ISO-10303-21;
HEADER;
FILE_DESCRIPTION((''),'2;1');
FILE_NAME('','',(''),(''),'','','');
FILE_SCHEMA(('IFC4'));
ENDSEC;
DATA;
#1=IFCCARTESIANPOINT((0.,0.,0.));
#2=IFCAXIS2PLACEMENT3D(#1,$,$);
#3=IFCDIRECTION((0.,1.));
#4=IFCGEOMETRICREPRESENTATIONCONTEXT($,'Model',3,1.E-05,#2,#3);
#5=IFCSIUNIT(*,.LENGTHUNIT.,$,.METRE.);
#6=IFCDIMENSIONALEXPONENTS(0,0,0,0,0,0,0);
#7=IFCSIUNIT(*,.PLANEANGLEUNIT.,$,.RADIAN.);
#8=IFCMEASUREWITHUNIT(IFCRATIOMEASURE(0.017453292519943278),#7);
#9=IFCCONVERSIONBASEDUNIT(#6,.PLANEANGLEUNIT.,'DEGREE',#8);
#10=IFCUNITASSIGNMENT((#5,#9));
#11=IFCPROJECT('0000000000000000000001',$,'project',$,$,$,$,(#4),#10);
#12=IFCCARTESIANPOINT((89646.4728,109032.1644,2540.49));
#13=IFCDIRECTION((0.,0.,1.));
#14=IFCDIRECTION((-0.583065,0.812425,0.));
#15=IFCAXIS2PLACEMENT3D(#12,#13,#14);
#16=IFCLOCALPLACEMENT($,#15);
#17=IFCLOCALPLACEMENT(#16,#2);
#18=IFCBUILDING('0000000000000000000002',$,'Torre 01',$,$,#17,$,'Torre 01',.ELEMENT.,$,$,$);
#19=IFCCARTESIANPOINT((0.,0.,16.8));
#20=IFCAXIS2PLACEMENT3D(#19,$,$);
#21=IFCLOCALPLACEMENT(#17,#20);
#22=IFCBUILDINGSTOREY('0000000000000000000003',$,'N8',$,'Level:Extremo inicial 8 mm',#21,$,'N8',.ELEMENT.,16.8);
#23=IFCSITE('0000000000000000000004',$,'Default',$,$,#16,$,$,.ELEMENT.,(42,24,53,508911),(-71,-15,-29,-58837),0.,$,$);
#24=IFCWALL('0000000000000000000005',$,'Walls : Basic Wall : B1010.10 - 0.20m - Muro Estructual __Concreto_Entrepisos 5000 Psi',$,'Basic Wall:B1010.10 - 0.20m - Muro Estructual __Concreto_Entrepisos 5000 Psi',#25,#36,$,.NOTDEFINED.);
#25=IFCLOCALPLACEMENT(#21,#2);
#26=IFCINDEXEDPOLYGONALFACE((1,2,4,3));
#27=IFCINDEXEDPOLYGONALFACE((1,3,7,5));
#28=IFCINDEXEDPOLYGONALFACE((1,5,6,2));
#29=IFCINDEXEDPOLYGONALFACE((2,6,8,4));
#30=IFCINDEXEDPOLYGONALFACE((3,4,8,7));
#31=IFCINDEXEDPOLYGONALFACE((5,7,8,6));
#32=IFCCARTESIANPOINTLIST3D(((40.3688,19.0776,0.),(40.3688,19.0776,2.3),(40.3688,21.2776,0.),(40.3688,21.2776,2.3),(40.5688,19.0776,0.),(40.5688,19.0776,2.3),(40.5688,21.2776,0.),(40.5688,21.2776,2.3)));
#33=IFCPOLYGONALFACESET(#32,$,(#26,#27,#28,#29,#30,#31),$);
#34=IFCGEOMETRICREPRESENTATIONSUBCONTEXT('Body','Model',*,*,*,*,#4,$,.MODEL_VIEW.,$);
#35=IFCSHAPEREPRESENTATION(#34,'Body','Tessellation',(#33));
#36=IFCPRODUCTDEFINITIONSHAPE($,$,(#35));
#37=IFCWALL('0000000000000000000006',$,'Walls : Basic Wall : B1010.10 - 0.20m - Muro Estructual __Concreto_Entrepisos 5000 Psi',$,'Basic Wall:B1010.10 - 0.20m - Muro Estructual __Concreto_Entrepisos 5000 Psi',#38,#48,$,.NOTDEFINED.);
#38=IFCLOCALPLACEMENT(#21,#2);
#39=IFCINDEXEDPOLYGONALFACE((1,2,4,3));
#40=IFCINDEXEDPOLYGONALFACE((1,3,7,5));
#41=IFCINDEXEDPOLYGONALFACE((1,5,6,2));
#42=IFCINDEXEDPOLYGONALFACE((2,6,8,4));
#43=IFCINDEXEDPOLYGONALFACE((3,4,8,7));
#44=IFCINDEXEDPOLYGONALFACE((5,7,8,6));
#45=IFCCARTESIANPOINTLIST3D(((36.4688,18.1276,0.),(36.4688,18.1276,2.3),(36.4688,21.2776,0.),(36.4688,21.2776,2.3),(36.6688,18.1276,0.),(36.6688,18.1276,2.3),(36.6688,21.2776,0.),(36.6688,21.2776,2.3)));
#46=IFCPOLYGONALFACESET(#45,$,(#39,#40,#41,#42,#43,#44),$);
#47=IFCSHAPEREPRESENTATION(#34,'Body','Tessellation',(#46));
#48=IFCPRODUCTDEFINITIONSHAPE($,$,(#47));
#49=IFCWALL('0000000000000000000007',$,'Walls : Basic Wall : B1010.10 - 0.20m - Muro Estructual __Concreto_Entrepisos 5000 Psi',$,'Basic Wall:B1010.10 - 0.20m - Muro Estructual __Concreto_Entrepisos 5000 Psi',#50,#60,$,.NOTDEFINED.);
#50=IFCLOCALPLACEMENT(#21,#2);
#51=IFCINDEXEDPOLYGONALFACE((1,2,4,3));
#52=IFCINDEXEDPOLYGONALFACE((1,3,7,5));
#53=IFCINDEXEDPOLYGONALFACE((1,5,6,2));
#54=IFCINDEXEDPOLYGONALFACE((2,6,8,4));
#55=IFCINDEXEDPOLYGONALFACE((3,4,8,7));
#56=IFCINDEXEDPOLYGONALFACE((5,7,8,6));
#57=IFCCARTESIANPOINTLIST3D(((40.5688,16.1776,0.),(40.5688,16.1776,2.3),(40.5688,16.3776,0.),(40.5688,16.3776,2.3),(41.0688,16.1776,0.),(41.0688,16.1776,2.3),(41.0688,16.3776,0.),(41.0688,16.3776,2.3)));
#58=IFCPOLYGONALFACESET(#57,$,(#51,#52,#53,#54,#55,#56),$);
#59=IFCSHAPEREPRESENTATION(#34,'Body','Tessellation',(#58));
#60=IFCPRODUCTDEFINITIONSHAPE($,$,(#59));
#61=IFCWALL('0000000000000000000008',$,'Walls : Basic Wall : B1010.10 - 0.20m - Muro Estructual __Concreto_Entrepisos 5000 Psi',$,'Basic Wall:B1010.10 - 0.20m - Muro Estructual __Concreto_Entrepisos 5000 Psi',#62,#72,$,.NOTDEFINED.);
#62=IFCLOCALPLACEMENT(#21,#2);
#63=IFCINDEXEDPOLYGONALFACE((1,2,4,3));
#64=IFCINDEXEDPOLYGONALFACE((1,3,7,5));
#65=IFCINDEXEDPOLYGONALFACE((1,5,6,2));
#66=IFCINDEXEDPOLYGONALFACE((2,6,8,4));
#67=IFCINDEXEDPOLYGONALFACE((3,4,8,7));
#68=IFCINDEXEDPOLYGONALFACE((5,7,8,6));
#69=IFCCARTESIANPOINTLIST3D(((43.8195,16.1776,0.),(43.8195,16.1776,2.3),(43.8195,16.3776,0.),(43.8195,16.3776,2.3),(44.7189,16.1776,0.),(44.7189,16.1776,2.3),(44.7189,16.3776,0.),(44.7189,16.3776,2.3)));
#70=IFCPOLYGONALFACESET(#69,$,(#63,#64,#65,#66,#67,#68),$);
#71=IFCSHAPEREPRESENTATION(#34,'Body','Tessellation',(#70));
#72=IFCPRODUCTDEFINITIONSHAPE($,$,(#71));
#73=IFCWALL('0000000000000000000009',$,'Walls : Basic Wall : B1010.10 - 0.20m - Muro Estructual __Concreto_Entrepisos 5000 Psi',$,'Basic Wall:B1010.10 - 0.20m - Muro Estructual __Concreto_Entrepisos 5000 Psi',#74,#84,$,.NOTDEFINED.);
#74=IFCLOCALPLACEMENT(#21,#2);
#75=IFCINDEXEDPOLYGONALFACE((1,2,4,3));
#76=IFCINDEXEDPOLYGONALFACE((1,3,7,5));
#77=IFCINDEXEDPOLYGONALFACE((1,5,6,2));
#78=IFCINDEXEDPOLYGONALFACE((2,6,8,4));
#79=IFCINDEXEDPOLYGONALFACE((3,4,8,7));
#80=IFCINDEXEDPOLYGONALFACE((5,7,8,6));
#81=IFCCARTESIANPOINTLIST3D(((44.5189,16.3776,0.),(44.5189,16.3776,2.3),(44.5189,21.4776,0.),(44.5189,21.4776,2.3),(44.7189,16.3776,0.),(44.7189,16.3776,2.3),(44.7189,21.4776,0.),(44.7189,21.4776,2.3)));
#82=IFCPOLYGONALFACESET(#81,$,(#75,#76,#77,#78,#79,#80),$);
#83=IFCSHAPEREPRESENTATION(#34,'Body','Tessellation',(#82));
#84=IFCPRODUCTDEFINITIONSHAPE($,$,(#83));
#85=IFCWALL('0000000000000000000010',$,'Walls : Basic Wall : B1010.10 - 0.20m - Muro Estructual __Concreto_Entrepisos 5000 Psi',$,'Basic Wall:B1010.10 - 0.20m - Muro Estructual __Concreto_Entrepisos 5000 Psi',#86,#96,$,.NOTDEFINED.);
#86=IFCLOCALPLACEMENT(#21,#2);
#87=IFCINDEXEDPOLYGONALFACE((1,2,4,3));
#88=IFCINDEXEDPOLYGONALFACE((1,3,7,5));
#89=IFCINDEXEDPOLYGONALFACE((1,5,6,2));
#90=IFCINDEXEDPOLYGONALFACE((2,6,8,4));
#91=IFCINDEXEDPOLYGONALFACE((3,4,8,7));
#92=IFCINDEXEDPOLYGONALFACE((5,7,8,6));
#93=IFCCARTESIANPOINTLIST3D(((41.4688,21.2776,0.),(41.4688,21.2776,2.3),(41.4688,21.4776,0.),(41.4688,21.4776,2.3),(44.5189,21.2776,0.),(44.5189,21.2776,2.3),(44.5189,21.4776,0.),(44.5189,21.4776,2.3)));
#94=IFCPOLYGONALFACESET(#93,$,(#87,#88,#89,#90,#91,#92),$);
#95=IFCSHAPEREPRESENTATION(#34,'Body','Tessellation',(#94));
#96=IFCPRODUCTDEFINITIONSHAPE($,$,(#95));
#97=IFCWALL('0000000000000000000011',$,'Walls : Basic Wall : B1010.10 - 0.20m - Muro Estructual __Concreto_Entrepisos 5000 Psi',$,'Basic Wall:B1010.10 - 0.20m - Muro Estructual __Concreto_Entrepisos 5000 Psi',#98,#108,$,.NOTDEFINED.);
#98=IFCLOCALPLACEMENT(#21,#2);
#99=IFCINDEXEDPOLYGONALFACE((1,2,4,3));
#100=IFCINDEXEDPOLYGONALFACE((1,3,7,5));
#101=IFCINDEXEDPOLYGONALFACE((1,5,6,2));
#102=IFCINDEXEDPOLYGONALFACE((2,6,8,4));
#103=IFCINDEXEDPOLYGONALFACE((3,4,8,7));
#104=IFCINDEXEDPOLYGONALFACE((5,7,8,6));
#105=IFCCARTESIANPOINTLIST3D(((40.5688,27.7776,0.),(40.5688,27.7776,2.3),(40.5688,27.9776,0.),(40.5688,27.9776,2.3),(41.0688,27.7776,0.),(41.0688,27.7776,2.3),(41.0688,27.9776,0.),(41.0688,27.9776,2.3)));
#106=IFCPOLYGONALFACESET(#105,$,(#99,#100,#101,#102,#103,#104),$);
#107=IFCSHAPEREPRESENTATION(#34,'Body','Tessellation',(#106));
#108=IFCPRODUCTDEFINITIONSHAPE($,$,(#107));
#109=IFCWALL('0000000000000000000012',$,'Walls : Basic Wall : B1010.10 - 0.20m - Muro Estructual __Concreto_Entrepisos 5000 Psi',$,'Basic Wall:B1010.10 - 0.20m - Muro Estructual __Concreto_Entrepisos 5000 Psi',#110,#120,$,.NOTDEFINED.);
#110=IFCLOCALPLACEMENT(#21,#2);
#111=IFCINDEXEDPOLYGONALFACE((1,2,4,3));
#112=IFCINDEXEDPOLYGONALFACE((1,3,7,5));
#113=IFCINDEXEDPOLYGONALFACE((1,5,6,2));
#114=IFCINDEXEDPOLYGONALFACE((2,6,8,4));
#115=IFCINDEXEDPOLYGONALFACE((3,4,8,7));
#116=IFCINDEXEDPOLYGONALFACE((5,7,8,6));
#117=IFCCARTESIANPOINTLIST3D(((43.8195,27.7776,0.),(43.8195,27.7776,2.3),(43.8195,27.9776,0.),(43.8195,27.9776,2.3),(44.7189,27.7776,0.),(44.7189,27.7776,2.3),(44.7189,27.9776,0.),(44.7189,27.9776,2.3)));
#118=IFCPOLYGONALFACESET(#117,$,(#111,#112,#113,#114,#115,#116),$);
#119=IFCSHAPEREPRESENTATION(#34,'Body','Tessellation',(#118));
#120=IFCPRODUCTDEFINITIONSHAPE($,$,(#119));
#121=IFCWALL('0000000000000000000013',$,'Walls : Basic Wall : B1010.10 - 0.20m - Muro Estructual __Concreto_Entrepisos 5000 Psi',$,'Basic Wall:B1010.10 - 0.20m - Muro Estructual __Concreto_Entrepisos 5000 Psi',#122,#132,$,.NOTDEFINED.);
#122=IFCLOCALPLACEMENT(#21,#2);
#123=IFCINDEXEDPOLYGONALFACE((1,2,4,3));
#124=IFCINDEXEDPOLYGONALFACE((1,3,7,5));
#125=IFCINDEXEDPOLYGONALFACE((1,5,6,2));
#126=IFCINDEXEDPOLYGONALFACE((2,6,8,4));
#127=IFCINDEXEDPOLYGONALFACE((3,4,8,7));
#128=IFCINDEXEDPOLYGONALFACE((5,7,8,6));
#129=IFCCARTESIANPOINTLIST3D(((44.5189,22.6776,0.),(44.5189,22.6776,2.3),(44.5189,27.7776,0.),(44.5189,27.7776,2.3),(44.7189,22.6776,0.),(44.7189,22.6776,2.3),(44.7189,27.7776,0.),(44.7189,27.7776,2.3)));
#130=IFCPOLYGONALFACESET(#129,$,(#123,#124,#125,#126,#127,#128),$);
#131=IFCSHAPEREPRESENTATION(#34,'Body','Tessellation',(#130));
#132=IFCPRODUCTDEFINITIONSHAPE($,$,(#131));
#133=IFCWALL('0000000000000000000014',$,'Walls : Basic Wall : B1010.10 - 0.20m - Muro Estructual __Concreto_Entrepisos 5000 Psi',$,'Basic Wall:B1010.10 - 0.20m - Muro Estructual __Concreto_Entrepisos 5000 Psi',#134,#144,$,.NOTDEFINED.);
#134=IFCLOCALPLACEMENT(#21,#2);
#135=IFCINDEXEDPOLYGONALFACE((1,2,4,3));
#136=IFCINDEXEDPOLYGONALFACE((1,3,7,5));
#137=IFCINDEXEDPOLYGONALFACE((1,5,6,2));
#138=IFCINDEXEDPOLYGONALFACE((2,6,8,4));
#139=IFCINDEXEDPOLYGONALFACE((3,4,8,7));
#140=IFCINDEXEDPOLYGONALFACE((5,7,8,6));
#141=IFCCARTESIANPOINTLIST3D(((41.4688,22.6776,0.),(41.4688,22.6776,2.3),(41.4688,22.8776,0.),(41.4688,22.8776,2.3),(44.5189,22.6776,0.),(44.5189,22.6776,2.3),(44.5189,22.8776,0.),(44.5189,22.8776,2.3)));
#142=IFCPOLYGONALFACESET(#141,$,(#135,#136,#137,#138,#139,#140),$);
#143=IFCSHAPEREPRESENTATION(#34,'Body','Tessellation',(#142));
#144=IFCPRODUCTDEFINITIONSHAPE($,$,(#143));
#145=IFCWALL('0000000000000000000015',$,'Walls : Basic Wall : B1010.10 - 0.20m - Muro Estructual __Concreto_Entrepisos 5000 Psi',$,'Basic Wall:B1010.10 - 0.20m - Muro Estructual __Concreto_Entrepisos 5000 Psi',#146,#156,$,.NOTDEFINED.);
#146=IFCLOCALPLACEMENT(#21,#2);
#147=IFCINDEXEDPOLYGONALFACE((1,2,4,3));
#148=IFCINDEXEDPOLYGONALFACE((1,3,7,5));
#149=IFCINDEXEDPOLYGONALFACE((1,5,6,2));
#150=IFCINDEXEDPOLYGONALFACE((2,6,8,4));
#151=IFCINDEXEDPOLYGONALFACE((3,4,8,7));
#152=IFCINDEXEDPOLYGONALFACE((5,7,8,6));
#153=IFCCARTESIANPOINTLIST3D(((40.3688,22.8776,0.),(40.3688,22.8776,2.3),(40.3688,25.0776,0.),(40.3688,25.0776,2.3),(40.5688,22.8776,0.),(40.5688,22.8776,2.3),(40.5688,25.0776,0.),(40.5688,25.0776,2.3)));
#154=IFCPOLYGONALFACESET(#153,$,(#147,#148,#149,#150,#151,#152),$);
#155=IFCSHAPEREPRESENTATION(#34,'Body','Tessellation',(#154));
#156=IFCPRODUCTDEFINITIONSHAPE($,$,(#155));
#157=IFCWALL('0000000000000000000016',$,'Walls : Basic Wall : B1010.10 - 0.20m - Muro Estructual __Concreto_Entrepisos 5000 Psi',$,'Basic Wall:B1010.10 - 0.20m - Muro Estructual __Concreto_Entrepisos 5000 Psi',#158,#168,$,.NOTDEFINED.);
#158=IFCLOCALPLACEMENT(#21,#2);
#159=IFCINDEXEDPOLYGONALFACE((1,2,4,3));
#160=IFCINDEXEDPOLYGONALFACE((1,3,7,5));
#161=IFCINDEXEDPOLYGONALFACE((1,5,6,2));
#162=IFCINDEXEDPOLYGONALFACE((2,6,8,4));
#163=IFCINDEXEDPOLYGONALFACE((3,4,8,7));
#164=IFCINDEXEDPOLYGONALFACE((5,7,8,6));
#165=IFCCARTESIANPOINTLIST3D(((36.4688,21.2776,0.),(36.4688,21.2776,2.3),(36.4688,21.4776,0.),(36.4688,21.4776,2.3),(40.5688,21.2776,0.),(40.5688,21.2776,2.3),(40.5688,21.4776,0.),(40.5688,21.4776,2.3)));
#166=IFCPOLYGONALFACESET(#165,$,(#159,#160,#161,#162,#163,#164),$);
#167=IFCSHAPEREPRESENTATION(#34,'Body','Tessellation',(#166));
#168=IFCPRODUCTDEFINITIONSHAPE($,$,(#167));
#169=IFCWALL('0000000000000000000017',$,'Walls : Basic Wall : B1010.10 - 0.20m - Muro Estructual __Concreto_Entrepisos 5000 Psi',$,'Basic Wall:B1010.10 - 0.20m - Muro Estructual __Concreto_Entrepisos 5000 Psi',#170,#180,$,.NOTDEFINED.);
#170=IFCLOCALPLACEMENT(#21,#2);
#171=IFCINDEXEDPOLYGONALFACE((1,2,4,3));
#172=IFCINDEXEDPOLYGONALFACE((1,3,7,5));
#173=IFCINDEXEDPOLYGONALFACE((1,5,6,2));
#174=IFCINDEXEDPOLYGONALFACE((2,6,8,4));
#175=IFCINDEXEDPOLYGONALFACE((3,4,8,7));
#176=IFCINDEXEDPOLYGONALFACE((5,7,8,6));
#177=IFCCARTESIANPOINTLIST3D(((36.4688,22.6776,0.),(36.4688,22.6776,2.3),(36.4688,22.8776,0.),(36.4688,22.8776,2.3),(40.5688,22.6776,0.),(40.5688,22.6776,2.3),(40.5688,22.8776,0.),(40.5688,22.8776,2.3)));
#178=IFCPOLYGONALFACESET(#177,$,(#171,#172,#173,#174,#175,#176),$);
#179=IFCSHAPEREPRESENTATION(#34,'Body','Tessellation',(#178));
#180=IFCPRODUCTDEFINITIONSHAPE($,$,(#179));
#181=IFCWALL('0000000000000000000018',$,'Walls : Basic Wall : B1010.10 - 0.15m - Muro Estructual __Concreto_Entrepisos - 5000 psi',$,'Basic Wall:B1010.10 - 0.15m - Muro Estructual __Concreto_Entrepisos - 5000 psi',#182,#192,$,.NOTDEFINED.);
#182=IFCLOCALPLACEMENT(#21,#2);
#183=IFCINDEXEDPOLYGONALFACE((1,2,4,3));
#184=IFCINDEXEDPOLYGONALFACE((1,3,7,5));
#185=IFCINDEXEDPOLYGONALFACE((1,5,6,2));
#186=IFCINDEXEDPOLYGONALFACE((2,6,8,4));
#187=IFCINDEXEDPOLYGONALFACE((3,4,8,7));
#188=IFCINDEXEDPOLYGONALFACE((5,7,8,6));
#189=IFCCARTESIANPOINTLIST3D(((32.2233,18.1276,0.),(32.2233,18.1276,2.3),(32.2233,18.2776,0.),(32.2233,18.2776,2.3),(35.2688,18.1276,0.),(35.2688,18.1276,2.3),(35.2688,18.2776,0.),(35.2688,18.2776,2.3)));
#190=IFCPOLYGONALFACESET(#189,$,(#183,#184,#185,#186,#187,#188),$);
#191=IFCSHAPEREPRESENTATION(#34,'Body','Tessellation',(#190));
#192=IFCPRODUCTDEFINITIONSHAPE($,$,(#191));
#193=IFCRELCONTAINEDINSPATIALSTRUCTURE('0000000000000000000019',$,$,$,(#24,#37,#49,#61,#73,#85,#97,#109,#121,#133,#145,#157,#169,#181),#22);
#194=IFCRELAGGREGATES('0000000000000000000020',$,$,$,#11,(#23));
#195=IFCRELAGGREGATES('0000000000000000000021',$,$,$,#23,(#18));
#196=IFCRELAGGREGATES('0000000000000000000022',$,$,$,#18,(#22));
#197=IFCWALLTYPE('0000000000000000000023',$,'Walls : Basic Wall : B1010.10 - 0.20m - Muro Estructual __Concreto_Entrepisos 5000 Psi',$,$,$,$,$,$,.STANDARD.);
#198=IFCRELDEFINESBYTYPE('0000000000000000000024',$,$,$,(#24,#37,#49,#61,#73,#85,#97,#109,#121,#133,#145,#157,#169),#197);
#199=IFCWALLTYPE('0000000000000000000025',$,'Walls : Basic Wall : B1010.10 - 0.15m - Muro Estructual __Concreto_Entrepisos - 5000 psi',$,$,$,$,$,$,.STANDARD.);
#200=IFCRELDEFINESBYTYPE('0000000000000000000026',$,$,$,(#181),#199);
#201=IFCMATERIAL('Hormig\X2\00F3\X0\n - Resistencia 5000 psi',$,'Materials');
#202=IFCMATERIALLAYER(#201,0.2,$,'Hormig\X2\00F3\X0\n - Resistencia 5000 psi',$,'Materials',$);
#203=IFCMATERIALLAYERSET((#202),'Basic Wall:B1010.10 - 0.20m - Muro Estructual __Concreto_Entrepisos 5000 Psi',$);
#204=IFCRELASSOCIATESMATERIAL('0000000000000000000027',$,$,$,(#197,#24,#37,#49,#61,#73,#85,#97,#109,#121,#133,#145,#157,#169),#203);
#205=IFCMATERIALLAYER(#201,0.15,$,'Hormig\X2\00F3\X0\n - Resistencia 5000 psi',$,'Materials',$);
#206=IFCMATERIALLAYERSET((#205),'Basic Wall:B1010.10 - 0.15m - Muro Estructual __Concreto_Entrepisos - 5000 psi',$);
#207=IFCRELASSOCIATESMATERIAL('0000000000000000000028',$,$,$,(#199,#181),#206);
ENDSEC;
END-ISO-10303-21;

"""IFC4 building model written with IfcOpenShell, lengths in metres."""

from ifc_helpers import new_model, entity, si_unit, converted_unit, direction, frame, frame_2d, origin, place, context, subcontext, project, spatial, rectangle, extrude, material, layer, layer_set, layer_usage, type_object, element, save


model = new_model("IFC4")

# Units and contexts
model_context = context("Model", 3, precision=1e-05, world=origin(), true_north=direction((0.0, 1.0)))
body_context = subcontext(model_context, "Body", "Model", "MODEL_VIEW")
ifc_project = project(units=[si_unit("LENGTHUNIT", "METRE"), converted_unit("PLANEANGLEUNIT", "DEGREE", entity("IfcRatioMeasure", 0.017453292519943278), si_unit("PLANEANGLEUNIT", "RADIAN"), dimensions=[0, 0, 0, 0, 0, 0, 0])], contexts=[model_context])

# Site, building, storey
site_placement = place(None, frame((89646.4728, 109032.1644, 2540.49), z_axis=(0.0, 0.0, 1.0), x_axis=(-0.583065, 0.812425, 0.0)))
site = spatial("IfcSite", under=ifc_project, at=site_placement, Name="Default", CompositionType="ELEMENT", RefLatitude=(42, 24, 53, 508911), RefLongitude=(-71, -15, -29, -58837), RefElevation=0.0)
building_placement = place(site_placement, origin())
building = spatial("IfcBuilding", under=site, at=building_placement, Name="Torre 01", LongName="Torre 01", CompositionType="ELEMENT")
storey_placement = place(building_placement, frame((0.0, 0.0, 16.8)))
storey = spatial("IfcBuildingStorey", under=building, at=storey_placement, Name="N8", ObjectType="Level:Extremo inicial 8 mm", LongName="N8", CompositionType="ELEMENT", Elevation=16.8)

# Walls
ifc_material = material(Name="Hormigón - Resistencia 5000 psi", Category="Materials")
ifc_layer_1 = layer(ifc_material, 0.2, Name="Hormigón - Resistencia 5000 psi", Category="Materials")
ifc_layer_set_1 = layer_set([ifc_layer_1], Name="Basic Wall:B1010.10 - 0.20m - Muro Estructual __Concreto_Entrepisos 5000 Psi")
ifc_layer_usage_1 = layer_usage(ifc_layer_set_1, "AXIS2", "NEGATIVE", 0.1)
wall_type_1 = type_object("IfcWallType", Name="Walls : Basic Wall : B1010.10 - 0.20m - Muro Estructual __Concreto_Entrepisos 5000 Psi", PredefinedType="STANDARD", material=ifc_layer_set_1)
wall_1_placement = place(storey_placement, frame((40.4688, 21.2776, 0.0), z_axis=(0.0, 0.0, 1.0), x_axis=(0.0, -1.0, 0.0)))
element("IfcWall", 1, at=wall_1_placement, inside=storey, type_object=wall_type_1, material=ifc_layer_usage_1, Name="Walls : Basic Wall : B1010.10 - 0.20m - Muro Estructual __Concreto_Entrepisos 5000 Psi", ObjectType="Basic Wall:B1010.10 - 0.20m - Muro Estructual __Concreto_Entrepisos 5000 Psi", PredefinedType="NOTDEFINED", context=body_context, shape_type="SweptSolid", body=[
    extrude(rectangle(XDim=2.2, YDim=0.2, at=frame_2d((1.1, 0.0), x_axis=(-1.0, 0.0))), origin(), (0.0, 0.0, 1.0), 2.3),
])
ifc_layer_usage_2 = layer_usage(ifc_layer_set_1, "AXIS2", "NEGATIVE", 0.1)
wall_2_placement = place(storey_placement, frame((36.5688, 18.1276, 0.0), z_axis=(0.0, 0.0, 1.0), x_axis=(0.0, 1.0, 0.0)))
element("IfcWall", 2, at=wall_2_placement, inside=storey, type_object=wall_type_1, material=ifc_layer_usage_2, Name="Walls : Basic Wall : B1010.10 - 0.20m - Muro Estructual __Concreto_Entrepisos 5000 Psi", ObjectType="Basic Wall:B1010.10 - 0.20m - Muro Estructual __Concreto_Entrepisos 5000 Psi", PredefinedType="NOTDEFINED", context=body_context, shape_type="SweptSolid", body=[
    extrude(rectangle(XDim=3.15, YDim=0.2, at=frame_2d((1.575, 0.0), x_axis=(-1.0, 0.0))), origin(), (0.0, 0.0, 1.0), 2.3),
])
ifc_layer_usage_3 = layer_usage(ifc_layer_set_1, "AXIS2", "NEGATIVE", 0.1)
wall_3_placement = place(storey_placement, frame((41.0688, 16.2776, 0.0), z_axis=(0.0, 0.0, 1.0), x_axis=(-1.0, 0.0, 0.0)))
element("IfcWall", 3, at=wall_3_placement, inside=storey, type_object=wall_type_1, material=ifc_layer_usage_3, Name="Walls : Basic Wall : B1010.10 - 0.20m - Muro Estructual __Concreto_Entrepisos 5000 Psi", ObjectType="Basic Wall:B1010.10 - 0.20m - Muro Estructual __Concreto_Entrepisos 5000 Psi", PredefinedType="NOTDEFINED", context=body_context, shape_type="SweptSolid", body=[
    extrude(rectangle(XDim=0.5, YDim=0.2, at=frame_2d((0.25, 0.0), x_axis=(-1.0, 0.0))), origin(), (0.0, 0.0, 1.0), 2.3),
])
ifc_layer_usage_4 = layer_usage(ifc_layer_set_1, "AXIS2", "NEGATIVE", 0.1)
wall_4_placement = place(storey_placement, frame((43.8195, 16.2776, 0.0)))
element("IfcWall", 4, at=wall_4_placement, inside=storey, type_object=wall_type_1, material=ifc_layer_usage_4, Name="Walls : Basic Wall : B1010.10 - 0.20m - Muro Estructual __Concreto_Entrepisos 5000 Psi", ObjectType="Basic Wall:B1010.10 - 0.20m - Muro Estructual __Concreto_Entrepisos 5000 Psi", PredefinedType="NOTDEFINED", context=body_context, shape_type="SweptSolid", body=[
    extrude(rectangle(XDim=0.8993, YDim=0.2, at=frame_2d((0.4497, 0.0), x_axis=(-1.0, 0.0))), origin(), (0.0, 0.0, 1.0), 2.3),
])
ifc_layer_usage_5 = layer_usage(ifc_layer_set_1, "AXIS2", "NEGATIVE", 0.1)
wall_5_placement = place(storey_placement, frame((44.6189, 21.4776, 0.0), z_axis=(0.0, 0.0, 1.0), x_axis=(0.0, -1.0, 0.0)))
element("IfcWall", 5, at=wall_5_placement, inside=storey, type_object=wall_type_1, material=ifc_layer_usage_5, Name="Walls : Basic Wall : B1010.10 - 0.20m - Muro Estructual __Concreto_Entrepisos 5000 Psi", ObjectType="Basic Wall:B1010.10 - 0.20m - Muro Estructual __Concreto_Entrepisos 5000 Psi", PredefinedType="NOTDEFINED", context=body_context, shape_type="SweptSolid", body=[
    extrude(rectangle(XDim=5.1, YDim=0.2, at=frame_2d((2.55, 0.0), x_axis=(-1.0, 0.0))), origin(), (0.0, 0.0, 1.0), 2.3),
])
ifc_layer_usage_6 = layer_usage(ifc_layer_set_1, "AXIS2", "NEGATIVE", 0.1)
wall_6_placement = place(storey_placement, frame((41.4688, 21.3776, 0.0)))
element("IfcWall", 6, at=wall_6_placement, inside=storey, type_object=wall_type_1, material=ifc_layer_usage_6, Name="Walls : Basic Wall : B1010.10 - 0.20m - Muro Estructual __Concreto_Entrepisos 5000 Psi", ObjectType="Basic Wall:B1010.10 - 0.20m - Muro Estructual __Concreto_Entrepisos 5000 Psi", PredefinedType="NOTDEFINED", context=body_context, shape_type="SweptSolid", body=[
    extrude(rectangle(XDim=3.05, YDim=0.2, at=frame_2d((1.525, 0.0), x_axis=(-1.0, 0.0))), origin(), (0.0, 0.0, 1.0), 2.3),
])
ifc_layer_usage_7 = layer_usage(ifc_layer_set_1, "AXIS2", "POSITIVE", -0.1)
wall_7_placement = place(storey_placement, frame((41.0688, 27.8776, 0.0), z_axis=(0.0, 0.0, 1.0), x_axis=(-1.0, 0.0, 0.0)))
element("IfcWall", 7, at=wall_7_placement, inside=storey, type_object=wall_type_1, material=ifc_layer_usage_7, Name="Walls : Basic Wall : B1010.10 - 0.20m - Muro Estructual __Concreto_Entrepisos 5000 Psi", ObjectType="Basic Wall:B1010.10 - 0.20m - Muro Estructual __Concreto_Entrepisos 5000 Psi", PredefinedType="NOTDEFINED", context=body_context, shape_type="SweptSolid", body=[
    extrude(rectangle(XDim=0.5, YDim=0.2, at=frame_2d((0.25, 0.0), x_axis=(-1.0, 0.0))), origin(), (0.0, 0.0, 1.0), 2.3),
])
ifc_layer_usage_8 = layer_usage(ifc_layer_set_1, "AXIS2", "POSITIVE", -0.1)
wall_8_placement = place(storey_placement, frame((43.8195, 27.8776, 0.0)))
element("IfcWall", 8, at=wall_8_placement, inside=storey, type_object=wall_type_1, material=ifc_layer_usage_8, Name="Walls : Basic Wall : B1010.10 - 0.20m - Muro Estructual __Concreto_Entrepisos 5000 Psi", ObjectType="Basic Wall:B1010.10 - 0.20m - Muro Estructual __Concreto_Entrepisos 5000 Psi", PredefinedType="NOTDEFINED", context=body_context, shape_type="SweptSolid", body=[
    extrude(rectangle(XDim=0.8993, YDim=0.2, at=frame_2d((0.4497, 0.0), x_axis=(-1.0, 0.0))), origin(), (0.0, 0.0, 1.0), 2.3),
])
ifc_layer_usage_9 = layer_usage(ifc_layer_set_1, "AXIS2", "POSITIVE", -0.1)
wall_9_placement = place(storey_placement, frame((44.6189, 22.6776, 0.0), z_axis=(0.0, 0.0, 1.0), x_axis=(0.0, 1.0, 0.0)))
element("IfcWall", 9, at=wall_9_placement, inside=storey, type_object=wall_type_1, material=ifc_layer_usage_9, Name="Walls : Basic Wall : B1010.10 - 0.20m - Muro Estructual __Concreto_Entrepisos 5000 Psi", ObjectType="Basic Wall:B1010.10 - 0.20m - Muro Estructual __Concreto_Entrepisos 5000 Psi", PredefinedType="NOTDEFINED", context=body_context, shape_type="SweptSolid", body=[
    extrude(rectangle(XDim=5.1, YDim=0.2, at=frame_2d((2.55, 0.0), x_axis=(-1.0, 0.0))), origin(), (0.0, 0.0, 1.0), 2.3),
])
ifc_layer_usage_10 = layer_usage(ifc_layer_set_1, "AXIS2", "POSITIVE", -0.1)
wall_10_placement = place(storey_placement, frame((41.4688, 22.7776, 0.0)))
element("IfcWall", 10, at=wall_10_placement, inside=storey, type_object=wall_type_1, material=ifc_layer_usage_10, Name="Walls : Basic Wall : B1010.10 - 0.20m - Muro Estructual __Concreto_Entrepisos 5000 Psi", ObjectType="Basic Wall:B1010.10 - 0.20m - Muro Estructual __Concreto_Entrepisos 5000 Psi", PredefinedType="NOTDEFINED", context=body_context, shape_type="SweptSolid", body=[
    extrude(rectangle(XDim=3.05, YDim=0.2, at=frame_2d((1.525, 0.0), x_axis=(-1.0, 0.0))), origin(), (0.0, 0.0, 1.0), 2.3),
])
ifc_layer_usage_11 = layer_usage(ifc_layer_set_1, "AXIS2", "POSITIVE", -0.1)
wall_11_placement = place(storey_placement, frame((40.4688, 22.8776, 0.0), z_axis=(0.0, 0.0, 1.0), x_axis=(0.0, 1.0, 0.0)))
element("IfcWall", 11, at=wall_11_placement, inside=storey, type_object=wall_type_1, material=ifc_layer_usage_11, Name="Walls : Basic Wall : B1010.10 - 0.20m - Muro Estructual __Concreto_Entrepisos 5000 Psi", ObjectType="Basic Wall:B1010.10 - 0.20m - Muro Estructual __Concreto_Entrepisos 5000 Psi", PredefinedType="NOTDEFINED", context=body_context, shape_type="SweptSolid", body=[
    extrude(rectangle(XDim=2.2, YDim=0.2, at=frame_2d((1.1, 0.0), x_axis=(-1.0, 0.0))), origin(), (0.0, 0.0, 1.0), 2.3),
])
ifc_layer_usage_12 = layer_usage(ifc_layer_set_1, "AXIS2", "NEGATIVE", 0.1)
wall_12_placement = place(storey_placement, frame((36.4688, 21.3776, 0.0)))
element("IfcWall", 12, at=wall_12_placement, inside=storey, type_object=wall_type_1, material=ifc_layer_usage_12, Name="Walls : Basic Wall : B1010.10 - 0.20m - Muro Estructual __Concreto_Entrepisos 5000 Psi", ObjectType="Basic Wall:B1010.10 - 0.20m - Muro Estructual __Concreto_Entrepisos 5000 Psi", PredefinedType="NOTDEFINED", context=body_context, shape_type="SweptSolid", body=[
    extrude(rectangle(XDim=4.1, YDim=0.2, at=frame_2d((2.05, 0.0), x_axis=(-1.0, 0.0))), origin(), (0.0, 0.0, 1.0), 2.3),
])
ifc_layer_usage_13 = layer_usage(ifc_layer_set_1, "AXIS2", "POSITIVE", -0.1)
wall_13_placement = place(storey_placement, frame((36.4688, 22.7776, 0.0)))
element("IfcWall", 13, at=wall_13_placement, inside=storey, type_object=wall_type_1, material=ifc_layer_usage_13, Name="Walls : Basic Wall : B1010.10 - 0.20m - Muro Estructual __Concreto_Entrepisos 5000 Psi", ObjectType="Basic Wall:B1010.10 - 0.20m - Muro Estructual __Concreto_Entrepisos 5000 Psi", PredefinedType="NOTDEFINED", context=body_context, shape_type="SweptSolid", body=[
    extrude(rectangle(XDim=4.1, YDim=0.2, at=frame_2d((2.05, 0.0), x_axis=(-1.0, 0.0))), origin(), (0.0, 0.0, 1.0), 2.3),
])
ifc_layer_2 = layer(ifc_material, 0.15, Name="Hormigón - Resistencia 5000 psi", Category="Materials")
ifc_layer_set_2 = layer_set([ifc_layer_2], Name="Basic Wall:B1010.10 - 0.15m - Muro Estructual __Concreto_Entrepisos - 5000 psi")
ifc_layer_usage_14 = layer_usage(ifc_layer_set_2, "AXIS2", "NEGATIVE", 0.075)
wall_type_2 = type_object("IfcWallType", Name="Walls : Basic Wall : B1010.10 - 0.15m - Muro Estructual __Concreto_Entrepisos - 5000 psi", PredefinedType="STANDARD", material=ifc_layer_set_2)
wall_14_placement = place(storey_placement, frame((32.2233, 18.2026, 0.0)))
element("IfcWall", 14, at=wall_14_placement, inside=storey, type_object=wall_type_2, material=ifc_layer_usage_14, Name="Walls : Basic Wall : B1010.10 - 0.15m - Muro Estructual __Concreto_Entrepisos - 5000 psi", ObjectType="Basic Wall:B1010.10 - 0.15m - Muro Estructual __Concreto_Entrepisos - 5000 psi", PredefinedType="NOTDEFINED", context=body_context, shape_type="SweptSolid", body=[
    extrude(rectangle(XDim=3.0455, YDim=0.15, at=frame_2d((1.5228, 0.0), x_axis=(-1.0, 0.0))), origin(), (0.0, 0.0, 1.0), 2.3),
])

save(model, "model.ifc")
